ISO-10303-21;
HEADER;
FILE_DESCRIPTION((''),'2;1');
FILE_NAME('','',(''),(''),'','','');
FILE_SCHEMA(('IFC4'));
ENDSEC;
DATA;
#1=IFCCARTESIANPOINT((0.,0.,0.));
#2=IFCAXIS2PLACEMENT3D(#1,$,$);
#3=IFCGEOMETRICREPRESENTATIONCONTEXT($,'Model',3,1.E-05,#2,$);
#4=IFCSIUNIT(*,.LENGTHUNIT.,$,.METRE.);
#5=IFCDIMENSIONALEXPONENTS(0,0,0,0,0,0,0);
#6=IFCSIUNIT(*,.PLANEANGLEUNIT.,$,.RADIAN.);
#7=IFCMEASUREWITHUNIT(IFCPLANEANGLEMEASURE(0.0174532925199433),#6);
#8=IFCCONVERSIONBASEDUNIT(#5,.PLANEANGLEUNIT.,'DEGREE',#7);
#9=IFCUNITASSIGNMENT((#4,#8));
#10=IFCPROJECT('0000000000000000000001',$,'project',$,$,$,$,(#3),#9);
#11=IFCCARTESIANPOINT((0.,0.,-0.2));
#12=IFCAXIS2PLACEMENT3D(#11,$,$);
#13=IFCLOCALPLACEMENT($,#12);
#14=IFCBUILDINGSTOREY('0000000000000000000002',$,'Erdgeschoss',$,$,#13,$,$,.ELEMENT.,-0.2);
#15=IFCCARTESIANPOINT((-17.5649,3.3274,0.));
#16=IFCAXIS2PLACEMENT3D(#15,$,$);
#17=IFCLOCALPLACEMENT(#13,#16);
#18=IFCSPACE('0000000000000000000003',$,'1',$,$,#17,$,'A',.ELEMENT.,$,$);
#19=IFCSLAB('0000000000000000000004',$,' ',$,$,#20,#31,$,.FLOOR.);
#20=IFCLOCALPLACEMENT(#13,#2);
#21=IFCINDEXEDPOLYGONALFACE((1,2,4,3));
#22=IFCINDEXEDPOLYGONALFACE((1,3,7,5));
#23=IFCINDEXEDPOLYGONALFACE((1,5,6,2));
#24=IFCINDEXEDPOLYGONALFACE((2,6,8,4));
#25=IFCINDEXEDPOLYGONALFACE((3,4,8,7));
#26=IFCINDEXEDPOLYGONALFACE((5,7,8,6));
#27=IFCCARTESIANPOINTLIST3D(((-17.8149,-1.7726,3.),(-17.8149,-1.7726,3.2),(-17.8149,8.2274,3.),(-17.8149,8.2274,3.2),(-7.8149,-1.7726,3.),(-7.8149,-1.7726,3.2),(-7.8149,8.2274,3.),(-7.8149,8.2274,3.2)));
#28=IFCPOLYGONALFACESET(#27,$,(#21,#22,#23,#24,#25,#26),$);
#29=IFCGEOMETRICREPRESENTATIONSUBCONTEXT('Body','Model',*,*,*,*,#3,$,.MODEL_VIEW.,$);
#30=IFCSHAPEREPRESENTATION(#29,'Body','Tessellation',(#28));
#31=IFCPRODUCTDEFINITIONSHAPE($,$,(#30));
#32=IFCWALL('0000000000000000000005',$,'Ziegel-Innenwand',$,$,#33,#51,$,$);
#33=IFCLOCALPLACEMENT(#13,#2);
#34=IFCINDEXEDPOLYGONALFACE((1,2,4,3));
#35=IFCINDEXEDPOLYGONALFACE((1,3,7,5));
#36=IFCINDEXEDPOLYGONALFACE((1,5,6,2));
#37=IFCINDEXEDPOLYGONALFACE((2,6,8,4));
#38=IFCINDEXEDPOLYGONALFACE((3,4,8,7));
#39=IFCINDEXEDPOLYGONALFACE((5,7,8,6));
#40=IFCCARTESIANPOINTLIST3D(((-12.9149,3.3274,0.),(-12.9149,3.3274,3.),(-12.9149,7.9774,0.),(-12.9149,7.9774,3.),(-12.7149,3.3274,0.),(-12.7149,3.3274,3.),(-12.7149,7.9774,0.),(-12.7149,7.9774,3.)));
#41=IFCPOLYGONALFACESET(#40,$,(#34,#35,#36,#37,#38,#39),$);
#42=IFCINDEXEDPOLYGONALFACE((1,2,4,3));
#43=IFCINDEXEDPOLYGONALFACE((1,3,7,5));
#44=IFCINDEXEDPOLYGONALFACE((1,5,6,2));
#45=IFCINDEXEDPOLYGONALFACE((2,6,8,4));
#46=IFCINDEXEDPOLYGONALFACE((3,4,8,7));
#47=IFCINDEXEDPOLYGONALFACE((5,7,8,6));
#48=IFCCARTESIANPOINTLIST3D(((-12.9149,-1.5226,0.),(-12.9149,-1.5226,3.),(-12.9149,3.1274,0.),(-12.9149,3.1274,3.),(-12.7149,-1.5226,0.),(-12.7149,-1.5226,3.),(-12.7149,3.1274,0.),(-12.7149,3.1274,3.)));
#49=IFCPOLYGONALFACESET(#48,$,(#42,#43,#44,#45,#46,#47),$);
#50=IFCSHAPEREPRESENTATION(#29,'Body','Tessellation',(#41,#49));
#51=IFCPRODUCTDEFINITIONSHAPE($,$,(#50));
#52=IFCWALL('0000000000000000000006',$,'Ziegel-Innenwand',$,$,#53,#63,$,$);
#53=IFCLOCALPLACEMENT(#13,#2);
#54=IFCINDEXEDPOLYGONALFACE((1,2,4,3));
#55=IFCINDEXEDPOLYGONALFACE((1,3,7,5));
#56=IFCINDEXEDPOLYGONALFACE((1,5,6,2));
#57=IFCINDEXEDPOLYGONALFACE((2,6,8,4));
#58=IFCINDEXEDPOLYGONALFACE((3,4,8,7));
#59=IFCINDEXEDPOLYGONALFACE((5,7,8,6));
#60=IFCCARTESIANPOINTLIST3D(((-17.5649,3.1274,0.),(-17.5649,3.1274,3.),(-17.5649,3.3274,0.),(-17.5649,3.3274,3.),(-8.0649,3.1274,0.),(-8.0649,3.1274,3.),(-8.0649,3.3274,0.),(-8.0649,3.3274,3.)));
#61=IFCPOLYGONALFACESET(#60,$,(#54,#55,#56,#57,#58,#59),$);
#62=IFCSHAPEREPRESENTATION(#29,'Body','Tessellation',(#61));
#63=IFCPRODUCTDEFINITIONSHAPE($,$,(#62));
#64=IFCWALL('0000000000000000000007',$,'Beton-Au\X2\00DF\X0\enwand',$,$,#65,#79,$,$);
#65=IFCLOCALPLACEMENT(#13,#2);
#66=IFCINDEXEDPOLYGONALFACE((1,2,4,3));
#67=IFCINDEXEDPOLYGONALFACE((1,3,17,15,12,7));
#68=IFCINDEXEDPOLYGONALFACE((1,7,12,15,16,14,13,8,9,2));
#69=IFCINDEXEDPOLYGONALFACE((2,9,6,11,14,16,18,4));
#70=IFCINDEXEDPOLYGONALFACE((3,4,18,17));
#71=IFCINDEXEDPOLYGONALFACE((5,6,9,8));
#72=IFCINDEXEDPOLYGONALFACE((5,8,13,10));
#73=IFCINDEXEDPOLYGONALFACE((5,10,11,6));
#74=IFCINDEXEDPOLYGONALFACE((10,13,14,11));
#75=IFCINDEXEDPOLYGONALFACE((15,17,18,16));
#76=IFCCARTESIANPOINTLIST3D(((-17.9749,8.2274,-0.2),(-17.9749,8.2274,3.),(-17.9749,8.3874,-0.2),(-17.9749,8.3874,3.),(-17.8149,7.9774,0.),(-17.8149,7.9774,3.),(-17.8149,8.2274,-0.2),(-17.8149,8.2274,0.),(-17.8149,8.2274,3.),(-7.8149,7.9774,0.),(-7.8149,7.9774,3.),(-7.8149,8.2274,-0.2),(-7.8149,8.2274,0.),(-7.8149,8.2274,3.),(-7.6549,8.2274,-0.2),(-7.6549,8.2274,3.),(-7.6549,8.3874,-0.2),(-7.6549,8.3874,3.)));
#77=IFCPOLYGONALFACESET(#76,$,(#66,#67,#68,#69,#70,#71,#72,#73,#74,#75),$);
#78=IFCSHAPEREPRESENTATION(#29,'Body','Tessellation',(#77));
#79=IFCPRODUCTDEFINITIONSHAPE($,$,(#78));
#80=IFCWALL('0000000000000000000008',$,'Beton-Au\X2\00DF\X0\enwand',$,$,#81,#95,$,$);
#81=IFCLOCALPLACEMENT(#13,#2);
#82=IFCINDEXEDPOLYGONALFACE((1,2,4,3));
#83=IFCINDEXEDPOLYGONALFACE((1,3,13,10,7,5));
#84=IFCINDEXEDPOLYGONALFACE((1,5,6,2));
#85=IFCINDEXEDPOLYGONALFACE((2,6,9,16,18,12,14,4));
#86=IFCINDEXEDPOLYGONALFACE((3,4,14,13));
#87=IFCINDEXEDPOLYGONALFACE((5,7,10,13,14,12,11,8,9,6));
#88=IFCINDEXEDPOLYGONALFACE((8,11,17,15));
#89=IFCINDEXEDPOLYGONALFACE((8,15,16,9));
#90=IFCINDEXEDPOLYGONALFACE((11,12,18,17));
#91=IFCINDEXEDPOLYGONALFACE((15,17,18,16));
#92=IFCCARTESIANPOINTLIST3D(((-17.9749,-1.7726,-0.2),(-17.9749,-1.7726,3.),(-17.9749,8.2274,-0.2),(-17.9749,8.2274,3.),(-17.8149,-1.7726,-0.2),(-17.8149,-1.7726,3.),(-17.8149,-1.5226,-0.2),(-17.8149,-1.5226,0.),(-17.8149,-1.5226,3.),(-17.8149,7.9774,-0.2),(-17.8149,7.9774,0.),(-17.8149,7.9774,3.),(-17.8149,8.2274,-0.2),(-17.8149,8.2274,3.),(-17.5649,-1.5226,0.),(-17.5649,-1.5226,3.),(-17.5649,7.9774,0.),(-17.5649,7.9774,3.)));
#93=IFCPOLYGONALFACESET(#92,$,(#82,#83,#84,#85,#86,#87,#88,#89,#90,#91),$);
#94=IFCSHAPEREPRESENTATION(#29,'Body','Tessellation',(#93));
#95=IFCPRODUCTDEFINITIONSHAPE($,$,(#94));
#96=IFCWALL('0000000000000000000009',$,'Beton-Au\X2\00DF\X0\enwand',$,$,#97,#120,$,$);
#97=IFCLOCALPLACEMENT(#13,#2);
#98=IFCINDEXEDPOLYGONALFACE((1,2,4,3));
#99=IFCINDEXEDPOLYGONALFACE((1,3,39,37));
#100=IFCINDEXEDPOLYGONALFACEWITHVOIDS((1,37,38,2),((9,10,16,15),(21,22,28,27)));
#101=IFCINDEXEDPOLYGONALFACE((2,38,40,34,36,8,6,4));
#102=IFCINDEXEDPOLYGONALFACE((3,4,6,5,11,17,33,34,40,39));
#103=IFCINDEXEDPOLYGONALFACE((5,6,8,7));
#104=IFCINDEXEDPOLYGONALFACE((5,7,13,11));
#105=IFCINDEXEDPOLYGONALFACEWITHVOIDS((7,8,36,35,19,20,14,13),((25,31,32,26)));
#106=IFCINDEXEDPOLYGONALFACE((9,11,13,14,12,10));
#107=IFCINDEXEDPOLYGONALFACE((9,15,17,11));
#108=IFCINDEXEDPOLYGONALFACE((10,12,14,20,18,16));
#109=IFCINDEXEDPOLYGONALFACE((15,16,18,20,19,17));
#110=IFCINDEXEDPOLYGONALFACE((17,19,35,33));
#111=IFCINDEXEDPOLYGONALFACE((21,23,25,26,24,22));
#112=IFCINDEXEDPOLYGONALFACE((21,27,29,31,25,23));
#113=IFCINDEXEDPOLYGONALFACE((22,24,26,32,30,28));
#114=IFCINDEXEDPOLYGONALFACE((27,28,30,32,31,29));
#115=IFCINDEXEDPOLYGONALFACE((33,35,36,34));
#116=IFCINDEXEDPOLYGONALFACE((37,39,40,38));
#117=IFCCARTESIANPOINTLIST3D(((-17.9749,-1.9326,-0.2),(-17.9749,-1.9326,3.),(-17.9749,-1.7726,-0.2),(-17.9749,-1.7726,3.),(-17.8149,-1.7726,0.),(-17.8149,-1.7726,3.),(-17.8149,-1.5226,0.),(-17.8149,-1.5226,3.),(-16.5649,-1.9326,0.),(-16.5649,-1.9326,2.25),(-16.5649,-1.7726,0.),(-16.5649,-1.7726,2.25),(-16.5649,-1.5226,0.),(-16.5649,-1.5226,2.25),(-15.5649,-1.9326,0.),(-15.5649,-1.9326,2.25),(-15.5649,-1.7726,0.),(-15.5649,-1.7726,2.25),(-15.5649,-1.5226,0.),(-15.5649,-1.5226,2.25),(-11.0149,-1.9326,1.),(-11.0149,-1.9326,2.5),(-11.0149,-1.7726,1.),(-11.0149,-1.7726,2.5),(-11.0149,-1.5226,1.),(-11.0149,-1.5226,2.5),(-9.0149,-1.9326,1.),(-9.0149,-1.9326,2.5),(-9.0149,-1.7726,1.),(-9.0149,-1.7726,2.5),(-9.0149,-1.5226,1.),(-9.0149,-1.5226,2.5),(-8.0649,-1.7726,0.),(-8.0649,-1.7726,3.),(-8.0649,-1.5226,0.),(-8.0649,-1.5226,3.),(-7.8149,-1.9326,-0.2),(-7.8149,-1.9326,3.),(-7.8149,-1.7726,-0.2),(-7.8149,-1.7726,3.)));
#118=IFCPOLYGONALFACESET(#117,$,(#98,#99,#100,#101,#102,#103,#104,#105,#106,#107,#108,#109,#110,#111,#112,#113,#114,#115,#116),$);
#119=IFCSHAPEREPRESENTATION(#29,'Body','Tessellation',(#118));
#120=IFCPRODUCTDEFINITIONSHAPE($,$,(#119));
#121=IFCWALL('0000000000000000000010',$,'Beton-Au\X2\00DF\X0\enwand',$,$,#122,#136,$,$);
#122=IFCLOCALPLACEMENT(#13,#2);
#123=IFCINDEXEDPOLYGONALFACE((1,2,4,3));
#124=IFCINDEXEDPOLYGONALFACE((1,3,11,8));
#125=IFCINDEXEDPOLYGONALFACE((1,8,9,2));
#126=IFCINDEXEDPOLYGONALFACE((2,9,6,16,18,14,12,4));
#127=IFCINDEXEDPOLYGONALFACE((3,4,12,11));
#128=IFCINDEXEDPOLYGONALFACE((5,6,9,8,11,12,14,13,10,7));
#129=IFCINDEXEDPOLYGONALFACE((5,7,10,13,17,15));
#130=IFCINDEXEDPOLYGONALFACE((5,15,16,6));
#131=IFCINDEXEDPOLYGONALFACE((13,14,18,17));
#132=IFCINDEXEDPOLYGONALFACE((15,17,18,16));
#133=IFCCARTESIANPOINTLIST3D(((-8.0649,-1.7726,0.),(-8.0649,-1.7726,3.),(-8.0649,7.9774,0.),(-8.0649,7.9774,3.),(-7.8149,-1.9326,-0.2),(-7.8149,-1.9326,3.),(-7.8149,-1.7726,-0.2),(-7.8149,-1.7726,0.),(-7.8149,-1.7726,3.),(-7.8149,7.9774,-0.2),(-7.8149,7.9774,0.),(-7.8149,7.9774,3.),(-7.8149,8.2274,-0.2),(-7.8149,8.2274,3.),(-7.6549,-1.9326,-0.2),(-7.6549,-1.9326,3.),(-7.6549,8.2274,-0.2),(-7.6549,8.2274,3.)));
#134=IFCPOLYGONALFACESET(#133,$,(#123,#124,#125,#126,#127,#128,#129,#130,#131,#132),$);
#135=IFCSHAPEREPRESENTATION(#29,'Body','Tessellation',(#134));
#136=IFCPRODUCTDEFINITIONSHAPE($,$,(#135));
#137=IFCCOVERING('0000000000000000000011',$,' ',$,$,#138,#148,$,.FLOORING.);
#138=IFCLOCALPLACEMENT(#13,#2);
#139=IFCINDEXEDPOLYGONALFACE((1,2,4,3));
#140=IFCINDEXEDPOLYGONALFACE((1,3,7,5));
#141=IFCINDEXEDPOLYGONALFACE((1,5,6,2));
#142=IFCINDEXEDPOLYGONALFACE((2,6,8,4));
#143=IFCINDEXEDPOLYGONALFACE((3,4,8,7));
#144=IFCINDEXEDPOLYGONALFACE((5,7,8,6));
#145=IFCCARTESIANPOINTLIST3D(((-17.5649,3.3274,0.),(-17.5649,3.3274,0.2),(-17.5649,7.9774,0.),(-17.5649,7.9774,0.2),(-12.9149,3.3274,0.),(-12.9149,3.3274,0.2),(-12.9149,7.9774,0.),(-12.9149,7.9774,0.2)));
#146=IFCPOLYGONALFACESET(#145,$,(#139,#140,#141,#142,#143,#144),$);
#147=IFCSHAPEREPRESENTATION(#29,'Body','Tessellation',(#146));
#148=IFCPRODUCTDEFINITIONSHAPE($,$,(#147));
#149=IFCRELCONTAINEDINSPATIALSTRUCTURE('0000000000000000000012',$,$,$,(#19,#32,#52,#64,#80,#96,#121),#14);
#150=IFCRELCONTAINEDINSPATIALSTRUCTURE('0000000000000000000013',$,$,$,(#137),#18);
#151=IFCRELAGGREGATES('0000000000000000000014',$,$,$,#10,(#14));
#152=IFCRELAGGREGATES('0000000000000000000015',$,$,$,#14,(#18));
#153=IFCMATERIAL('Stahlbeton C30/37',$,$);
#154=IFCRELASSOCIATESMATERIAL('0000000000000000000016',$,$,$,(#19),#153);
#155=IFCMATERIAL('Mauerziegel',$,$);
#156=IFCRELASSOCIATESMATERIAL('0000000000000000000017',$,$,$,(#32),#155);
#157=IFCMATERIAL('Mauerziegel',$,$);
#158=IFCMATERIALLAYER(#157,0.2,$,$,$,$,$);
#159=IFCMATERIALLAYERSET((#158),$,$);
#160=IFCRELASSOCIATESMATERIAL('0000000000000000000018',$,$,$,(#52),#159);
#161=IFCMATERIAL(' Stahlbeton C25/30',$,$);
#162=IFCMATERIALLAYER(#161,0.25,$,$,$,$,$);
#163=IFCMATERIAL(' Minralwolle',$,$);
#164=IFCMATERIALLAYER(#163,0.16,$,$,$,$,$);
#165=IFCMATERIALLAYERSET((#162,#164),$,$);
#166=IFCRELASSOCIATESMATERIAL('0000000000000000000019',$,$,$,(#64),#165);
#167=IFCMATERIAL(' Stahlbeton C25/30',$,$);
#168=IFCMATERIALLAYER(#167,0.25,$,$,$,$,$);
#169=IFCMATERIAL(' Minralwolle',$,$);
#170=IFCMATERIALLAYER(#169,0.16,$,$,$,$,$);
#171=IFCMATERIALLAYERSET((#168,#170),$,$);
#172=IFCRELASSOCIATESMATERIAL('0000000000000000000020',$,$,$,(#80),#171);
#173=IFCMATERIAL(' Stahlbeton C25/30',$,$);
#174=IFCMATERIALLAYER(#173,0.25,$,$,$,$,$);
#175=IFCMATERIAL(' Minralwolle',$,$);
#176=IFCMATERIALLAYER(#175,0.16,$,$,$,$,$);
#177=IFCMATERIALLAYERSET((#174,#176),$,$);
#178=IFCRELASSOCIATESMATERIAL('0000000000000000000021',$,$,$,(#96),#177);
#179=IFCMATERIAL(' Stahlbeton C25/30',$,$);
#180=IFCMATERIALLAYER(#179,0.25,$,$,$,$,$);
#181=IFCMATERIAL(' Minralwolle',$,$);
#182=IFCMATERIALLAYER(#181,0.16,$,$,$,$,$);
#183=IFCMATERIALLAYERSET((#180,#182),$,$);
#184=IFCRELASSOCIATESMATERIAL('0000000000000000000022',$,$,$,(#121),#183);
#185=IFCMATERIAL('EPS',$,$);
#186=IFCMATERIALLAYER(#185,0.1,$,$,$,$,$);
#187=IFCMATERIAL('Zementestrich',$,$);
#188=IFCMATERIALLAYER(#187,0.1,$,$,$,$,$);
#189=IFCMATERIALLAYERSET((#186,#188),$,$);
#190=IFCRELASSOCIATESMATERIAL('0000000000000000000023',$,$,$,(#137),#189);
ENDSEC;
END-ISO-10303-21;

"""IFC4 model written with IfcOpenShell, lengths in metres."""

from ifc_helpers import new_model, entity, si_unit, converted_unit, frame, frame_2d, origin, origin_with_axes, place, context, subcontext, project, spatial, polyline, rectangle, outline, extrude, clip, bounded_halfspace, material, layer, layer_set, layer_usage, element, save


model = new_model("IFC4")

# Units and contexts
model_context = context("Model", 3, precision=1e-05, world=origin())
body_context = subcontext(model_context, "Body", "Model", "MODEL_VIEW")
ifc_project = project(units=[si_unit("LENGTHUNIT", "METRE"), converted_unit("PLANEANGLEUNIT", "DEGREE", entity("IfcPlaneAngleMeasure", 0.0174532925199433), si_unit("PLANEANGLEUNIT", "RADIAN"), dimensions=[0, 0, 0, 0, 0, 0, 0])], contexts=[model_context])

# Storey
storey_placement = place(None, frame((0.0, 0.0, -0.2)))
storey = spatial("IfcBuildingStorey", under=ifc_project, at=storey_placement, Name="Erdgeschoss", CompositionType="ELEMENT", Elevation=-0.2)

# Slab
ifc_material_1 = material(Name="Stahlbeton C30/37")
slab_placement = place(storey_placement, frame((-17.8149, -1.7726, 3.0)))
element("IfcSlab", 1, at=slab_placement, inside=storey, material=ifc_material_1, Name=" ", PredefinedType="FLOOR", context=body_context, shape_type="SweptSolid", body=[
    extrude(rectangle(XDim=10.0, YDim=10.0, at=frame_2d((5.0, -5.0), x_axis=(0.0, -1.0))), frame((0.0, 10.0, 0.0), z_axis=(0.0, 0.0, 1.0), x_axis=(1.0, 0.0, 0.0)), (0.0, 0.0, 1.0), 0.2),
])

# Walls
ifc_material_2 = material(Name="Mauerziegel")
wall_1_placement = place(storey_placement, frame((-12.9149, 7.9774, 0.0), z_axis=(0.0, 0.0, 1.0), x_axis=(0.0, -1.0, 0.0)))
element("IfcWall", 2, at=wall_1_placement, inside=storey, material=ifc_material_2, Name="Ziegel-Innenwand", context=body_context, shape_type="SweptSolid", body=[
    extrude(rectangle(XDim=4.65, YDim=0.2, at=frame_2d((2.325, 0.1), x_axis=(1.0, 0.0))), origin_with_axes(), (0.0, 0.0, 1.0), 3.0),
    extrude(rectangle(XDim=4.65, YDim=0.2, at=frame_2d((2.325, 0.1), x_axis=(1.0, 0.0))), frame((4.85, 0.0, 0.0), z_axis=(0.0, 0.0, 1.0), x_axis=(1.0, 0.0, 0.0)), (0.0, 0.0, 1.0), 3.0),
])
ifc_material_3 = material(Name="Mauerziegel")
ifc_layer_1 = layer(ifc_material_3, 0.2)
ifc_layer_set_1 = layer_set([ifc_layer_1])
ifc_layer_usage_1 = layer_usage(ifc_layer_set_1, "AXIS2", "POSITIVE", -0.1)
wall_2_placement = place(storey_placement, frame((-8.0649, 3.3274, 0.0), z_axis=(0.0, 0.0, 1.0), x_axis=(-1.0, 0.0, 0.0)))
element("IfcWall", 3, at=wall_2_placement, inside=storey, material=ifc_layer_usage_1, Name="Ziegel-Innenwand", context=body_context, shape_type="SweptSolid", body=[
    extrude(rectangle(XDim=9.5, YDim=0.2, at=frame_2d((4.75, 0.1), x_axis=(1.0, 0.0))), origin_with_axes(), (0.0, 0.0, 1.0), 3.0),
])
ifc_material_4 = material(Name=" Stahlbeton C25/30")
ifc_layer_2 = layer(ifc_material_4, 0.25)
ifc_material_5 = material(Name=" Minralwolle")
ifc_layer_3 = layer(ifc_material_5, 0.16)
ifc_layer_set_2 = layer_set([ifc_layer_2, ifc_layer_3])
ifc_layer_usage_2 = layer_usage(ifc_layer_set_2, "AXIS2", "POSITIVE", -0.25)
wall_3_placement = place(storey_placement, frame((-17.8149, 7.9774, -0.2)))
element("IfcWall", 4, at=wall_3_placement, inside=storey, material=ifc_layer_usage_2, Name="Beton-Außenwand", context=body_context, shape_type="Clipping", body=[
    clip(extrude(outline(polyline([(0.16, 0.0), (10.16, 0.0), (10.16, 0.25), (10.32, 0.25), (10.32, 0.41), (0.0, 0.41), (0.0, 0.25), (0.16, 0.25), (0.16, 0.0)])), frame((-0.16, 0.0, 0.0), z_axis=(0.0, 0.0, 1.0), x_axis=(1.0, 0.0, 0.0)), (0.0, 0.0, 1.0), 3.2), bounded_halfspace(frame((5.0, 0.125, 0.2), z_axis=(0.0, 0.0, 1.0), x_axis=(0.0, -1.0, 0.0)), True, origin_with_axes(), polyline([(0.0, 0.25), (0.0, 0.0), (10.0, 0.0), (10.0, 0.25), (0.0, 0.25)]))),
])
ifc_material_6 = material(Name=" Stahlbeton C25/30")
ifc_layer_4 = layer(ifc_material_6, 0.25)
ifc_material_7 = material(Name=" Minralwolle")
ifc_layer_5 = layer(ifc_material_7, 0.16)
ifc_layer_set_3 = layer_set([ifc_layer_4, ifc_layer_5])
ifc_layer_usage_3 = layer_usage(ifc_layer_set_3, "AXIS2", "POSITIVE", -0.25)
wall_4_placement = place(storey_placement, frame((-17.5649, -1.5226, -0.2), z_axis=(0.0, 0.0, 1.0), x_axis=(0.0, 1.0, 0.0)))
element("IfcWall", 5, at=wall_4_placement, inside=storey, material=ifc_layer_usage_3, Name="Beton-Außenwand", context=body_context, shape_type="Clipping", body=[
    clip(extrude(outline(polyline([(0.25, -0.41), (9.75, -0.41), (9.75, -0.16), (10.0, -0.16), (10.0, 0.0), (0.0, 0.0), (0.0, -0.16), (0.25, -0.16), (0.25, -0.41)])), frame((-0.25, 0.41, 0.0), z_axis=(0.0, 0.0, 1.0), x_axis=(1.0, 0.0, 0.0)), (0.0, 0.0, 1.0), 3.2), bounded_halfspace(frame((4.75, 0.125, 0.2), z_axis=(0.0, 0.0, 1.0), x_axis=(0.0, -1.0, 0.0)), True, origin_with_axes(), polyline([(0.0, 0.25), (0.0, 0.0), (9.5, 0.0), (9.5, 0.25), (0.0, 0.25)]))),
])

# Wall, openings
ifc_material_8 = material(Name=" Stahlbeton C25/30")
ifc_layer_6 = layer(ifc_material_8, 0.25)
ifc_material_9 = material(Name=" Minralwolle")
ifc_layer_7 = layer(ifc_material_9, 0.16)
ifc_layer_set_4 = layer_set([ifc_layer_6, ifc_layer_7])
ifc_layer_usage_4 = layer_usage(ifc_layer_set_4, "AXIS2", "POSITIVE", -0.25)
wall_5_placement = place(storey_placement, frame((-8.0649, -1.5226, -0.2), z_axis=(0.0, 0.0, 1.0), x_axis=(-1.0, 0.0, 0.0)))
wall_5 = element("IfcWall", 6, at=wall_5_placement, inside=storey, material=ifc_layer_usage_4, Name="Beton-Außenwand", context=body_context, shape_type="Clipping", body=[
    clip(extrude(outline(polyline([(-9.91, -0.41), (-0.16, -0.41), (-0.16, -0.16), (0.0, -0.16), (0.0, 0.0), (-10.16, 0.0), (-10.16, -0.16), (-9.91, -0.16), (-9.91, -0.41)])), frame((9.91, 0.41, 0.0), z_axis=(0.0, 0.0, 1.0), x_axis=(1.0, 0.0, 0.0)), (0.0, 0.0, 1.0), 3.2), bounded_halfspace(frame((4.875, 0.125, 0.2), z_axis=(0.0, 0.0, 1.0), x_axis=(0.0, -1.0, 0.0)), True, origin_with_axes(), polyline([(0.0, 0.25), (0.0, 0.0), (9.75, 0.0), (9.75, 0.25), (0.0, 0.25)]))),
])
opening_1_placement = place(wall_5_placement, frame((8.5, 0.25, 0.2), z_axis=(0.0, -1.0, 0.0), x_axis=(0.0, 0.0, 1.0)))
element("IfcOpeningElement", 7, at=opening_1_placement, cuts=wall_5, PredefinedType="OPENING", context=body_context, shape_type="SweptSolid", body=[
    extrude(outline(polyline([(0.0, 1.0), (2.25, 1.0), (2.25, 0.0), (0.0, 0.0), (0.0, 1.0)])), origin_with_axes(), (0.0, 0.0, 1.0), 0.25),
    extrude(outline(polyline([(0.0, 1.0), (2.25, 1.0), (2.25, 0.0), (0.0, 0.0), (0.0, 1.0)])), frame((0.0, 0.0, -0.16), z_axis=(0.0, 0.0, 1.0), x_axis=(1.0, 0.0, 0.0)), (0.0, 0.0, 1.0), 0.16),
])
opening_2_placement = place(wall_5_placement, frame((2.95, 0.25, 1.2), z_axis=(0.0, -1.0, 0.0), x_axis=(0.0, 0.0, 1.0)))
element("IfcOpeningElement", 8, at=opening_2_placement, cuts=wall_5, ObjectType="Opening", context=body_context, shape_type="SweptSolid", body=[
    extrude(outline(polyline([(0.0, 2.0), (1.5, 2.0), (1.5, 0.0), (0.0, 0.0), (0.0, 2.0)])), origin_with_axes(), (0.0, 0.0, 1.0), 0.25),
    extrude(outline(polyline([(0.0, 2.0), (1.5, 2.0), (1.5, 0.0), (0.0, 0.0), (0.0, 2.0)])), frame((0.0, 0.0, -0.16), z_axis=(0.0, 0.0, 1.0), x_axis=(1.0, 0.0, 0.0)), (0.0, 0.0, 1.0), 0.16),
])

# Wall
ifc_material_10 = material(Name=" Stahlbeton C25/30")
ifc_layer_8 = layer(ifc_material_10, 0.25)
ifc_material_11 = material(Name=" Minralwolle")
ifc_layer_9 = layer(ifc_material_11, 0.16)
ifc_layer_set_5 = layer_set([ifc_layer_8, ifc_layer_9])
ifc_layer_usage_5 = layer_usage(ifc_layer_set_5, "AXIS2", "POSITIVE", -0.25)
wall_6_placement = place(storey_placement, frame((-8.0649, 7.9774, -0.2), z_axis=(0.0, 0.0, 1.0), x_axis=(0.0, -1.0, 0.0)))
element("IfcWall", 9, at=wall_6_placement, inside=storey, material=ifc_layer_usage_5, Name="Beton-Außenwand", context=body_context, shape_type="Clipping", body=[
    clip(extrude(outline(polyline([(-9.91, 0.0), (-0.16, 0.0), (-0.16, 0.25), (0.0, 0.25), (0.0, 0.41), (-10.16, 0.41), (-10.16, 0.25), (-9.91, 0.25), (-9.91, 0.0)])), frame((9.91, 0.0, 0.0), z_axis=(0.0, 0.0, 1.0), x_axis=(1.0, 0.0, 0.0)), (0.0, 0.0, 1.0), 3.2), bounded_halfspace(frame((4.875, 0.125, 0.2), z_axis=(0.0, 0.0, 1.0), x_axis=(0.0, -1.0, 0.0)), True, origin_with_axes(), polyline([(0.0, 0.25), (0.0, 0.0), (9.75, 0.0), (9.75, 0.25), (0.0, 0.25)]))),
])

# Shared definitions
space_1_placement = place(storey_placement, frame((-17.5649, 3.3274, 0.0)))
space_1 = spatial("IfcSpace", under=storey, at=space_1_placement, Name="1", LongName="A", CompositionType="ELEMENT")

# Covering
ifc_material_12 = material(Name="EPS")
ifc_layer_10 = layer(ifc_material_12, 0.1)
ifc_material_13 = material(Name="Zementestrich")
ifc_layer_11 = layer(ifc_material_13, 0.1)
ifc_layer_set_6 = layer_set([ifc_layer_10, ifc_layer_11])
ifc_layer_usage_6 = layer_usage(ifc_layer_set_6, "AXIS3", "POSITIVE", 0.0)
covering_1_placement = place(space_1_placement, origin())
element("IfcCovering", 10, at=covering_1_placement, inside=space_1, material=ifc_layer_usage_6, Name=" ", PredefinedType="FLOORING", context=body_context, shape_type="SweptSolid", body=[
    extrude(rectangle(XDim=4.65, YDim=4.65, at=frame_2d((2.325, 2.325), x_axis=(1.0, 0.0))), origin_with_axes(), (0.0, 0.0, 1.0), 0.2),
])

save(model, "model.ifc")
